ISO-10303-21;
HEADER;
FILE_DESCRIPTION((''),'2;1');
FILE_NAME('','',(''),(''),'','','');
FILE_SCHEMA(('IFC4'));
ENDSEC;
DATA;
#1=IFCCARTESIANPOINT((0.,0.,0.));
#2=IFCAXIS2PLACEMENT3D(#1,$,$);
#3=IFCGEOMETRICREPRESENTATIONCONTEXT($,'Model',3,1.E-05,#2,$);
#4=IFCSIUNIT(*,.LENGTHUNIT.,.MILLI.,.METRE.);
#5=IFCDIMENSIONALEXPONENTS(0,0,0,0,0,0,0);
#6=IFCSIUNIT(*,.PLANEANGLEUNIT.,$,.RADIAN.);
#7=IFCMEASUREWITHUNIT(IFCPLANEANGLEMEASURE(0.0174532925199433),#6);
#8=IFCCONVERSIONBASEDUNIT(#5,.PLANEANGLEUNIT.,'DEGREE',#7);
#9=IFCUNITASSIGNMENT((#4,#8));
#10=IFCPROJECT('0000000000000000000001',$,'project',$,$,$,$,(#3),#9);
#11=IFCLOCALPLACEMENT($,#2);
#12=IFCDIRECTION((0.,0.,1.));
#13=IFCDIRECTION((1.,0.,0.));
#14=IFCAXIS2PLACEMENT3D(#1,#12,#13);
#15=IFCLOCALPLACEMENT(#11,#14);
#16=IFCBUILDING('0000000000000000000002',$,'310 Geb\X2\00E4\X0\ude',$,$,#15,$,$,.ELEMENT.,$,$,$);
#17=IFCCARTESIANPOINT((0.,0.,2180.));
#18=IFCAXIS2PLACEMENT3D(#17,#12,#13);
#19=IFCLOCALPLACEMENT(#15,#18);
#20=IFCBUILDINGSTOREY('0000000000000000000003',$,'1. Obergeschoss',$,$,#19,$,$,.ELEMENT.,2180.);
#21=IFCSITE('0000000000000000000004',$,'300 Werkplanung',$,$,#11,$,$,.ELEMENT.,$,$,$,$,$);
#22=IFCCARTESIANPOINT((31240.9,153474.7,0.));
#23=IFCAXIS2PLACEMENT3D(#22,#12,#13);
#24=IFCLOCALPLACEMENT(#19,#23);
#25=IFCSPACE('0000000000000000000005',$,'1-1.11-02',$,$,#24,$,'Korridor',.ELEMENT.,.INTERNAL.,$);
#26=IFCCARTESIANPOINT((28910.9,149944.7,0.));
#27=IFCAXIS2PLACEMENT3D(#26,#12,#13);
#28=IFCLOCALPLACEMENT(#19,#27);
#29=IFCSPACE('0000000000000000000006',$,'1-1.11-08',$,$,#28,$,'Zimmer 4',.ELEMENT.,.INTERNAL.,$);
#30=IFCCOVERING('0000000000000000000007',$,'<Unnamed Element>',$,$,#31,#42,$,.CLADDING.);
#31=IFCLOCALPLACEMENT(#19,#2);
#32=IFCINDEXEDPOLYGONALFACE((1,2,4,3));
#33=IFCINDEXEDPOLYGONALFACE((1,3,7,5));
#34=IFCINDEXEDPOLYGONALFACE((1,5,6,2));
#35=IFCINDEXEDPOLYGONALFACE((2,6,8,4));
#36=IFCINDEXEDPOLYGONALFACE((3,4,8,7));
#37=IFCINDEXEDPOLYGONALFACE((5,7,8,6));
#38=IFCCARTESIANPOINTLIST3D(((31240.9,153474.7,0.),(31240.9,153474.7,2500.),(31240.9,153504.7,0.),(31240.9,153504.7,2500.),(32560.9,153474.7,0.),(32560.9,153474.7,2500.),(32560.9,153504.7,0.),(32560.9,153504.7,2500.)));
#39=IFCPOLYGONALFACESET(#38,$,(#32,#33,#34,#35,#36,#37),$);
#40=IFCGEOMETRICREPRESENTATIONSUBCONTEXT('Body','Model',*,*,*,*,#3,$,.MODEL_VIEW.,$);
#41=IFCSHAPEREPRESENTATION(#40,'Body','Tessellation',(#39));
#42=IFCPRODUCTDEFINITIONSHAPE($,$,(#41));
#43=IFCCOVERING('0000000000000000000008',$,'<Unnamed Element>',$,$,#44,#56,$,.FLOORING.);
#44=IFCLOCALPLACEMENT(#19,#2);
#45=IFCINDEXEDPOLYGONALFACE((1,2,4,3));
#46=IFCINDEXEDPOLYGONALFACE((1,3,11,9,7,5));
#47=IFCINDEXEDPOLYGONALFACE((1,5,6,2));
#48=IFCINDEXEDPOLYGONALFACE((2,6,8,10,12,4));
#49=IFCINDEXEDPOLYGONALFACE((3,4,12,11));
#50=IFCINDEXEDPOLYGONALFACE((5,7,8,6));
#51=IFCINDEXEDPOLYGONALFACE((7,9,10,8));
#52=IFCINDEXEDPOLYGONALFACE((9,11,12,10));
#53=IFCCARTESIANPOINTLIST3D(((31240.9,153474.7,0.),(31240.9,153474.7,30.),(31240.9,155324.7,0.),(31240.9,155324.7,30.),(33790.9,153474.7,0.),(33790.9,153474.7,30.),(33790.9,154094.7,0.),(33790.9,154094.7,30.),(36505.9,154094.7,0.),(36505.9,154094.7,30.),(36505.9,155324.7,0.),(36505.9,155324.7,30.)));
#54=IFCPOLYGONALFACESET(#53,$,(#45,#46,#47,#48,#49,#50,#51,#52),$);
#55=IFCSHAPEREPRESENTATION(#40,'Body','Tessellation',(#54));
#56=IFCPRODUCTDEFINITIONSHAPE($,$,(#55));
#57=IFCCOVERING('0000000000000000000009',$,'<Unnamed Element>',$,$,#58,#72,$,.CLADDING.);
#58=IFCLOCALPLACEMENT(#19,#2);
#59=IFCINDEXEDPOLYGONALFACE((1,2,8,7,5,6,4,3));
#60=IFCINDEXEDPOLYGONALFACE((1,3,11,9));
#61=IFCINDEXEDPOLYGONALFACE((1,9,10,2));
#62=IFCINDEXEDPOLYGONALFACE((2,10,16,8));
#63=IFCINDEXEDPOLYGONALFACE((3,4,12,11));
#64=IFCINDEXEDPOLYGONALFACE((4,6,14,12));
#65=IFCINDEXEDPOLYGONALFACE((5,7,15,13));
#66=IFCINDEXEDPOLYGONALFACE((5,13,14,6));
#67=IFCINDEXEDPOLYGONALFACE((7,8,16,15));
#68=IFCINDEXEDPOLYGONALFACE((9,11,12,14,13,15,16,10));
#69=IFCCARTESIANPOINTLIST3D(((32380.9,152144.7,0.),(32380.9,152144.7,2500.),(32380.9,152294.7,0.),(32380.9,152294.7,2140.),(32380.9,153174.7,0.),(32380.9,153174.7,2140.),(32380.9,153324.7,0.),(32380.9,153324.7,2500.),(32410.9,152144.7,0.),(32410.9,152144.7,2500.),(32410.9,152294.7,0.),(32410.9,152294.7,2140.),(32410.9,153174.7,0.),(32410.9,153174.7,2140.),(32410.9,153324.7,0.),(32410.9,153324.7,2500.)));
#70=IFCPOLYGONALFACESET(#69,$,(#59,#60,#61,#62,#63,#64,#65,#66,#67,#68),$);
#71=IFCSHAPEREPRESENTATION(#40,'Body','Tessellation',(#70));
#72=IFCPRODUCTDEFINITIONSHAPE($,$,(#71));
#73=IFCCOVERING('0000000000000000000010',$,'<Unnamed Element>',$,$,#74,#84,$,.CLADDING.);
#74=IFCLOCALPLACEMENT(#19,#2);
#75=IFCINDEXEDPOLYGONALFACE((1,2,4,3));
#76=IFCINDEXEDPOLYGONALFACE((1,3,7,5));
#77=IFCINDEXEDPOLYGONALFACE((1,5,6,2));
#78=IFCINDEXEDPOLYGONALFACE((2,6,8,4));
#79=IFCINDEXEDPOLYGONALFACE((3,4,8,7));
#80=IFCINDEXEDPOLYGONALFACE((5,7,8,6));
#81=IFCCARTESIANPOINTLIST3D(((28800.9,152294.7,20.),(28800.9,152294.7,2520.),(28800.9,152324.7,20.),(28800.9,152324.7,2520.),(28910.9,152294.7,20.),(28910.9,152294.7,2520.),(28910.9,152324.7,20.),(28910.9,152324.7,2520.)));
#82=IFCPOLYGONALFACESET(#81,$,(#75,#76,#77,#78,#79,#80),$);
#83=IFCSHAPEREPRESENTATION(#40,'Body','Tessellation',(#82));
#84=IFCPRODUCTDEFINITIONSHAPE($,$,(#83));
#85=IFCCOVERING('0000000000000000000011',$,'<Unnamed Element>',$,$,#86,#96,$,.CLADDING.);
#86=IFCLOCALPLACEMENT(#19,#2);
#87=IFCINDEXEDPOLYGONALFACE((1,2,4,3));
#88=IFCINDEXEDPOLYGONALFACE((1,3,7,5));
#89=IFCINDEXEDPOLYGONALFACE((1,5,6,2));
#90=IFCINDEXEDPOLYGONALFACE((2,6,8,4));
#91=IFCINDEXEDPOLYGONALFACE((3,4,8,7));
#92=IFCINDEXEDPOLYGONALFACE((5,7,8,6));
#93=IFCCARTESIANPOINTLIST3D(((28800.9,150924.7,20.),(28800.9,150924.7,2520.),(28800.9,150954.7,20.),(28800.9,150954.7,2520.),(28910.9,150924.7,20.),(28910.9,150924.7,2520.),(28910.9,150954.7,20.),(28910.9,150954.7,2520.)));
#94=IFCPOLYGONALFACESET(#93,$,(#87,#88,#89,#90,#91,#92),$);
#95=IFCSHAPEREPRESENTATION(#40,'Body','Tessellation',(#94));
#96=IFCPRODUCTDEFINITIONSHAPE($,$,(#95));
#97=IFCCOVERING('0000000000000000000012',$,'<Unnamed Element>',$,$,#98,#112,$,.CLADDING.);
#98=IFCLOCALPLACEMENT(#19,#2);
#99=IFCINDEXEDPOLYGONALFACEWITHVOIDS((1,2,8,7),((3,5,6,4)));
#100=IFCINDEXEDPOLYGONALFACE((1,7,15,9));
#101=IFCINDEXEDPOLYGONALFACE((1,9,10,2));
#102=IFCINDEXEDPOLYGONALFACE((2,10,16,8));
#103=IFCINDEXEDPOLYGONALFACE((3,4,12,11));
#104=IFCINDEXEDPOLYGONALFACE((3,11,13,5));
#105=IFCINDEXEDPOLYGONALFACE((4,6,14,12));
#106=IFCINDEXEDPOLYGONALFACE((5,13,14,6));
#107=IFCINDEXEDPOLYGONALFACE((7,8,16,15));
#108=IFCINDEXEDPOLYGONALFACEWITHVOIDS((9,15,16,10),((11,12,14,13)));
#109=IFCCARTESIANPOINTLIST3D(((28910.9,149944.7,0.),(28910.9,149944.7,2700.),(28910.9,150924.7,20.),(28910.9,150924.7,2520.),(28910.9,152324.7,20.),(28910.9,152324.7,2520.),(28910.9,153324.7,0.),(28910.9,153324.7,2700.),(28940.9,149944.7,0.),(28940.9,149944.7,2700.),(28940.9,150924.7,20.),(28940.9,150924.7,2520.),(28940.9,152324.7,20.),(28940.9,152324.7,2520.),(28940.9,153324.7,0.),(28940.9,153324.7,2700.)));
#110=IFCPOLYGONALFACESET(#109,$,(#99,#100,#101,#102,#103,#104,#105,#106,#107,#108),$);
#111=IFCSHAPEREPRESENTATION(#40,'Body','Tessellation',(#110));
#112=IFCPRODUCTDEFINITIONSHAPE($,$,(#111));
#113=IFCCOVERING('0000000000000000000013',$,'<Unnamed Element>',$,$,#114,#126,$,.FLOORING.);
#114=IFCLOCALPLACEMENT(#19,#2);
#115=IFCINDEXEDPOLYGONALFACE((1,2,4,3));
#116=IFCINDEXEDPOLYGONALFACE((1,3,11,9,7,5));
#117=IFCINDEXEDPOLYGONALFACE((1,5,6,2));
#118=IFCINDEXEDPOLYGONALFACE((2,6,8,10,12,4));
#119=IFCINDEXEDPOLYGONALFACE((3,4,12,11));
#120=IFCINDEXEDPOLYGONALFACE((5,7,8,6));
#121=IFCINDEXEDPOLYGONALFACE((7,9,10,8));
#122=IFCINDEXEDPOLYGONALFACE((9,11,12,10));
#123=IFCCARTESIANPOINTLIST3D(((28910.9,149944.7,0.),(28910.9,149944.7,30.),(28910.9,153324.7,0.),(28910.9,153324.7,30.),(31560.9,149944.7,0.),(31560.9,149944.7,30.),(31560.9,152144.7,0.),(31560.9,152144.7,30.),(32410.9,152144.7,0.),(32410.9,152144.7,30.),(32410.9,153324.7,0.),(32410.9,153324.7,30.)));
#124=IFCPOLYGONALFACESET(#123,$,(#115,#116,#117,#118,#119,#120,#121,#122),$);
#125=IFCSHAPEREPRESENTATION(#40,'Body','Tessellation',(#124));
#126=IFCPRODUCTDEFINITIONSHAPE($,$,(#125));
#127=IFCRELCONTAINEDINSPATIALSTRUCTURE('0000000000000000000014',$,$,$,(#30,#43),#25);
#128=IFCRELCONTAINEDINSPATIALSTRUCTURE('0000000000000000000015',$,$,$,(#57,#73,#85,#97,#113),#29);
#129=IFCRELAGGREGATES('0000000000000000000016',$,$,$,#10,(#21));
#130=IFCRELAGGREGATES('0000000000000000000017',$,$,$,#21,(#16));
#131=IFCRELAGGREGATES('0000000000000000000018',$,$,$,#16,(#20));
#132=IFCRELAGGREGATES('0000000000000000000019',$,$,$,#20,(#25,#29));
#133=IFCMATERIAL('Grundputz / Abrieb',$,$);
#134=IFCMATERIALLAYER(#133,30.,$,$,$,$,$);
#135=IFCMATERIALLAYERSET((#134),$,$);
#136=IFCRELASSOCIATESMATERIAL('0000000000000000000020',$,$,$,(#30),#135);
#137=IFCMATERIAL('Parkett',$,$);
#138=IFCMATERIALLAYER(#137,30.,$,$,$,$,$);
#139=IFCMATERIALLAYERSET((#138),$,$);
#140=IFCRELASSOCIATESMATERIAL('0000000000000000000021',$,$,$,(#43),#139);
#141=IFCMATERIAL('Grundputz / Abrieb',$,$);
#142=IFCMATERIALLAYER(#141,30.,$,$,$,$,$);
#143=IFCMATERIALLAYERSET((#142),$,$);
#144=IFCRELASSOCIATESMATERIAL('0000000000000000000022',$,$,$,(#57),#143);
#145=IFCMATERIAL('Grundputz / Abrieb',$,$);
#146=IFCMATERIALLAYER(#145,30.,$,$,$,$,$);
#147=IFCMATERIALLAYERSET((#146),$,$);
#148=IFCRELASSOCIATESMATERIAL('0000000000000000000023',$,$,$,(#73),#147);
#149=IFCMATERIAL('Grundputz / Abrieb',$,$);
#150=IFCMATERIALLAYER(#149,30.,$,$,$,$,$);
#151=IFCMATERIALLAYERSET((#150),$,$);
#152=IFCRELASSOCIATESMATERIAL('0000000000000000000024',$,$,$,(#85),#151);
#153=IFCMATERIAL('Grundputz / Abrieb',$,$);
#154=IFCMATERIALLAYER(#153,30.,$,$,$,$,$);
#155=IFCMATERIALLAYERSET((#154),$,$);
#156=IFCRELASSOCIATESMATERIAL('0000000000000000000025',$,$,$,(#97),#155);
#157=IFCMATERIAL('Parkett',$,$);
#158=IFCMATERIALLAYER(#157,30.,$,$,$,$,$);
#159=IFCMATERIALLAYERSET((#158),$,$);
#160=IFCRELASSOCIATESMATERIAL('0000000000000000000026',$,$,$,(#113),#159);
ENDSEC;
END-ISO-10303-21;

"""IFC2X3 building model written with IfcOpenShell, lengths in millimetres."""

from ifc_helpers import new_model, entity, si_unit, converted_unit, frame, frame_2d, origin, origin_with_axes, place, context, subcontext, project, spatial, polyline, rectangle, outline, extrude, material, layer, layer_set, layer_usage, element, save


model = new_model("IFC2X3")

# Units and contexts
model_context = context("Model", 3, precision=1e-05, world=origin())
body_context = subcontext(model_context, "Body", "Model", "MODEL_VIEW")
ifc_project = project(units=[si_unit("LENGTHUNIT", "METRE", prefix="MILLI"), converted_unit("PLANEANGLEUNIT", "DEGREE", entity("IfcPlaneAngleMeasure", 0.0174532925199433), si_unit("PLANEANGLEUNIT", "RADIAN"), dimensions=[0, 0, 0, 0, 0, 0, 0])], contexts=[model_context])

# Site, building, storey
site_placement = place(None, origin())
site = spatial("IfcSite", under=ifc_project, at=site_placement, Name="300 Werkplanung", CompositionType="ELEMENT")
building_placement = place(site_placement, origin_with_axes())
building = spatial("IfcBuilding", under=site, at=building_placement, Name="310 Gebäude", CompositionType="ELEMENT")
storey_placement = place(building_placement, frame((0.0, 0.0, 2180.0), z_axis=(0.0, 0.0, 1.0), x_axis=(1.0, 0.0, 0.0)))
storey = spatial("IfcBuildingStorey", under=building, at=storey_placement, Name="1. Obergeschoss", CompositionType="ELEMENT", Elevation=2180.0)

# Shared definitions
space_1_placement = place(storey_placement, frame((31240.9, 153474.7, 0.0), z_axis=(0.0, 0.0, 1.0), x_axis=(1.0, 0.0, 0.0)))
space_1 = spatial("IfcSpace", under=storey, at=space_1_placement, Name="1-1.11-02", LongName="Korridor", CompositionType="ELEMENT", InteriorOrExteriorSpace="INTERNAL")

# Coverings
ifc_material_1 = material(Name="Grundputz / Abrieb")
ifc_layer_1 = layer(ifc_material_1, 30.0)
ifc_layer_set_1 = layer_set([ifc_layer_1])
ifc_layer_usage_1 = layer_usage(ifc_layer_set_1, "AXIS3", "POSITIVE", 0.0)
covering_1_placement = place(space_1_placement, frame((0.0, 0.0, 0.0), z_axis=(0.0, 0.0, 1.0), x_axis=(1.0, 0.0, 0.0)))
element("IfcCovering", 1, at=covering_1_placement, inside=space_1, material=ifc_layer_usage_1, Name="<Unnamed Element>", PredefinedType="CLADDING", context=body_context, shape_type="SweptSolid", body=[
    extrude(rectangle(XDim=2500.0, YDim=1320.0, at=frame_2d((660.0, -1250.0), x_axis=(0.0, -1.0))), frame((0.0, 0.0, 0.0), z_axis=(0.0, 1.0, 0.0), x_axis=(1.0, 0.0, 0.0)), (0.0, 0.0, 1.0), 30.0),
])
ifc_material_2 = material(Name="Parkett")
ifc_layer_2 = layer(ifc_material_2, 30.0)
ifc_layer_set_2 = layer_set([ifc_layer_2])
ifc_layer_usage_2 = layer_usage(ifc_layer_set_2, "AXIS3", "POSITIVE", 0.0)
covering_2_placement = place(space_1_placement, origin_with_axes())
element("IfcCovering", 2, at=covering_2_placement, inside=space_1, material=ifc_layer_usage_2, Name="<Unnamed Element>", PredefinedType="FLOORING", context=body_context, shape_type="SweptSolid", body=[
    extrude(outline(polyline([(5265.0, 1850.0), (0.0, 1850.0), (0.0, 0.0), (2550.0, 0.0), (2550.0, 620.0), (5265.0, 620.0), (5265.0, 1850.0)])), origin_with_axes(), (0.0, 0.0, 1.0), 30.0),
])

# Shared definitions
space_2_placement = place(storey_placement, frame((28910.9, 149944.7, 0.0), z_axis=(0.0, 0.0, 1.0), x_axis=(1.0, 0.0, 0.0)))
space_2 = spatial("IfcSpace", under=storey, at=space_2_placement, Name="1-1.11-08", LongName="Zimmer 4", CompositionType="ELEMENT", InteriorOrExteriorSpace="INTERNAL")

# Coverings
ifc_material_3 = material(Name="Grundputz / Abrieb")
ifc_layer_3 = layer(ifc_material_3, 30.0)
ifc_layer_set_3 = layer_set([ifc_layer_3])
ifc_layer_usage_3 = layer_usage(ifc_layer_set_3, "AXIS3", "POSITIVE", 0.0)
covering_3_placement = place(space_2_placement, frame((3500.0, 2200.0, 0.0), z_axis=(0.0, 0.0, 1.0), x_axis=(0.0, 1.0, 0.0)))
element("IfcCovering", 3, at=covering_3_placement, inside=space_2, material=ifc_layer_usage_3, Name="<Unnamed Element>", PredefinedType="CLADDING", context=body_context, shape_type="SweptSolid", body=[
    extrude(outline(polyline([(1180.0, 0.0), (1180.0, -2500.0), (0.0, -2500.0), (0.0, 0.0), (150.0, 0.0), (150.0, -2140.0), (1030.0, -2140.0), (1030.0, 0.0), (1180.0, 0.0)])), frame((0.0, 0.0, 0.0), z_axis=(0.0, 1.0, 0.0), x_axis=(1.0, 0.0, 0.0)), (0.0, 0.0, 1.0), 30.0),
])
ifc_material_4 = material(Name="Grundputz / Abrieb")
ifc_layer_4 = layer(ifc_material_4, 30.0)
ifc_layer_set_4 = layer_set([ifc_layer_4])
ifc_layer_usage_4 = layer_usage(ifc_layer_set_4, "AXIS3", "POSITIVE", 0.0)
covering_4_placement = place(space_2_placement, frame((0.0, 2380.0, 20.0), z_axis=(0.0, 0.0, 1.0), x_axis=(-1.0, 0.0, 0.0)))
element("IfcCovering", 4, at=covering_4_placement, inside=space_2, material=ifc_layer_usage_4, Name="<Unnamed Element>", PredefinedType="CLADDING", context=body_context, shape_type="SweptSolid", body=[
    extrude(rectangle(XDim=2500.0, YDim=110.0, at=frame_2d((-55.0, 1250.0), x_axis=(0.0, 1.0))), frame((110.0, 0.0, 2500.0), z_axis=(0.0, 1.0, 0.0), x_axis=(1.0, 0.0, 0.0)), (0.0, 0.0, 1.0), 30.0),
])
ifc_material_5 = material(Name="Grundputz / Abrieb")
ifc_layer_5 = layer(ifc_material_5, 30.0)
ifc_layer_set_5 = layer_set([ifc_layer_5])
ifc_layer_usage_5 = layer_usage(ifc_layer_set_5, "AXIS3", "POSITIVE", 0.0)
covering_5_placement = place(space_2_placement, frame((-110.0, 980.0, 20.0), z_axis=(0.0, 0.0, 1.0), x_axis=(1.0, 0.0, 0.0)))
element("IfcCovering", 5, at=covering_5_placement, inside=space_2, material=ifc_layer_usage_5, Name="<Unnamed Element>", PredefinedType="CLADDING", context=body_context, shape_type="SweptSolid", body=[
    extrude(rectangle(XDim=2500.0, YDim=110.0, at=frame_2d((-55.0, 1250.0), x_axis=(0.0, 1.0))), frame((110.0, 0.0, 2500.0), z_axis=(0.0, 1.0, 0.0), x_axis=(1.0, 0.0, 0.0)), (0.0, 0.0, 1.0), 30.0),
])
ifc_material_6 = material(Name="Grundputz / Abrieb")
ifc_layer_6 = layer(ifc_material_6, 30.0)
ifc_layer_set_6 = layer_set([ifc_layer_6])
ifc_layer_usage_6 = layer_usage(ifc_layer_set_6, "AXIS3", "POSITIVE", 0.0)
covering_6_placement = place(space_2_placement, frame((0.0, 3380.0, 0.0), z_axis=(0.0, 0.0, 1.0), x_axis=(0.0, -1.0, 0.0)))
element("IfcCovering", 6, at=covering_6_placement, inside=space_2, material=ifc_layer_usage_6, Name="<Unnamed Element>", PredefinedType="CLADDING", context=body_context, shape_type="SweptSolid", body=[
    extrude(outline(polyline([(3380.0, 0.0), (3380.0, -2700.0), (0.0, -2700.0), (0.0, 0.0), (3380.0, 0.0)]), holes=[polyline([(2400.0, -20.0), (1000.0, -20.0), (1000.0, -2520.0), (2400.0, -2520.0), (2400.0, -20.0)])]), frame((0.0, 0.0, 0.0), z_axis=(0.0, 1.0, 0.0), x_axis=(1.0, 0.0, 0.0)), (0.0, 0.0, 1.0), 30.0),
])
ifc_material_7 = material(Name="Parkett")
ifc_layer_7 = layer(ifc_material_7, 30.0)
ifc_layer_set_7 = layer_set([ifc_layer_7])
ifc_layer_usage_7 = layer_usage(ifc_layer_set_7, "AXIS3", "POSITIVE", 0.0)
covering_7_placement = place(space_2_placement, origin_with_axes())
element("IfcCovering", 7, at=covering_7_placement, inside=space_2, material=ifc_layer_usage_7, Name="<Unnamed Element>", PredefinedType="FLOORING", context=body_context, shape_type="SweptSolid", body=[
    extrude(outline(polyline([(3500.0, 3380.0), (0.0, 3380.0), (0.0, 0.0), (2650.0, 0.0), (2650.0, 2200.0), (3500.0, 2200.0), (3500.0, 3380.0)])), origin_with_axes(), (0.0, 0.0, 1.0), 30.0),
])

save(model, "model.ifc")
